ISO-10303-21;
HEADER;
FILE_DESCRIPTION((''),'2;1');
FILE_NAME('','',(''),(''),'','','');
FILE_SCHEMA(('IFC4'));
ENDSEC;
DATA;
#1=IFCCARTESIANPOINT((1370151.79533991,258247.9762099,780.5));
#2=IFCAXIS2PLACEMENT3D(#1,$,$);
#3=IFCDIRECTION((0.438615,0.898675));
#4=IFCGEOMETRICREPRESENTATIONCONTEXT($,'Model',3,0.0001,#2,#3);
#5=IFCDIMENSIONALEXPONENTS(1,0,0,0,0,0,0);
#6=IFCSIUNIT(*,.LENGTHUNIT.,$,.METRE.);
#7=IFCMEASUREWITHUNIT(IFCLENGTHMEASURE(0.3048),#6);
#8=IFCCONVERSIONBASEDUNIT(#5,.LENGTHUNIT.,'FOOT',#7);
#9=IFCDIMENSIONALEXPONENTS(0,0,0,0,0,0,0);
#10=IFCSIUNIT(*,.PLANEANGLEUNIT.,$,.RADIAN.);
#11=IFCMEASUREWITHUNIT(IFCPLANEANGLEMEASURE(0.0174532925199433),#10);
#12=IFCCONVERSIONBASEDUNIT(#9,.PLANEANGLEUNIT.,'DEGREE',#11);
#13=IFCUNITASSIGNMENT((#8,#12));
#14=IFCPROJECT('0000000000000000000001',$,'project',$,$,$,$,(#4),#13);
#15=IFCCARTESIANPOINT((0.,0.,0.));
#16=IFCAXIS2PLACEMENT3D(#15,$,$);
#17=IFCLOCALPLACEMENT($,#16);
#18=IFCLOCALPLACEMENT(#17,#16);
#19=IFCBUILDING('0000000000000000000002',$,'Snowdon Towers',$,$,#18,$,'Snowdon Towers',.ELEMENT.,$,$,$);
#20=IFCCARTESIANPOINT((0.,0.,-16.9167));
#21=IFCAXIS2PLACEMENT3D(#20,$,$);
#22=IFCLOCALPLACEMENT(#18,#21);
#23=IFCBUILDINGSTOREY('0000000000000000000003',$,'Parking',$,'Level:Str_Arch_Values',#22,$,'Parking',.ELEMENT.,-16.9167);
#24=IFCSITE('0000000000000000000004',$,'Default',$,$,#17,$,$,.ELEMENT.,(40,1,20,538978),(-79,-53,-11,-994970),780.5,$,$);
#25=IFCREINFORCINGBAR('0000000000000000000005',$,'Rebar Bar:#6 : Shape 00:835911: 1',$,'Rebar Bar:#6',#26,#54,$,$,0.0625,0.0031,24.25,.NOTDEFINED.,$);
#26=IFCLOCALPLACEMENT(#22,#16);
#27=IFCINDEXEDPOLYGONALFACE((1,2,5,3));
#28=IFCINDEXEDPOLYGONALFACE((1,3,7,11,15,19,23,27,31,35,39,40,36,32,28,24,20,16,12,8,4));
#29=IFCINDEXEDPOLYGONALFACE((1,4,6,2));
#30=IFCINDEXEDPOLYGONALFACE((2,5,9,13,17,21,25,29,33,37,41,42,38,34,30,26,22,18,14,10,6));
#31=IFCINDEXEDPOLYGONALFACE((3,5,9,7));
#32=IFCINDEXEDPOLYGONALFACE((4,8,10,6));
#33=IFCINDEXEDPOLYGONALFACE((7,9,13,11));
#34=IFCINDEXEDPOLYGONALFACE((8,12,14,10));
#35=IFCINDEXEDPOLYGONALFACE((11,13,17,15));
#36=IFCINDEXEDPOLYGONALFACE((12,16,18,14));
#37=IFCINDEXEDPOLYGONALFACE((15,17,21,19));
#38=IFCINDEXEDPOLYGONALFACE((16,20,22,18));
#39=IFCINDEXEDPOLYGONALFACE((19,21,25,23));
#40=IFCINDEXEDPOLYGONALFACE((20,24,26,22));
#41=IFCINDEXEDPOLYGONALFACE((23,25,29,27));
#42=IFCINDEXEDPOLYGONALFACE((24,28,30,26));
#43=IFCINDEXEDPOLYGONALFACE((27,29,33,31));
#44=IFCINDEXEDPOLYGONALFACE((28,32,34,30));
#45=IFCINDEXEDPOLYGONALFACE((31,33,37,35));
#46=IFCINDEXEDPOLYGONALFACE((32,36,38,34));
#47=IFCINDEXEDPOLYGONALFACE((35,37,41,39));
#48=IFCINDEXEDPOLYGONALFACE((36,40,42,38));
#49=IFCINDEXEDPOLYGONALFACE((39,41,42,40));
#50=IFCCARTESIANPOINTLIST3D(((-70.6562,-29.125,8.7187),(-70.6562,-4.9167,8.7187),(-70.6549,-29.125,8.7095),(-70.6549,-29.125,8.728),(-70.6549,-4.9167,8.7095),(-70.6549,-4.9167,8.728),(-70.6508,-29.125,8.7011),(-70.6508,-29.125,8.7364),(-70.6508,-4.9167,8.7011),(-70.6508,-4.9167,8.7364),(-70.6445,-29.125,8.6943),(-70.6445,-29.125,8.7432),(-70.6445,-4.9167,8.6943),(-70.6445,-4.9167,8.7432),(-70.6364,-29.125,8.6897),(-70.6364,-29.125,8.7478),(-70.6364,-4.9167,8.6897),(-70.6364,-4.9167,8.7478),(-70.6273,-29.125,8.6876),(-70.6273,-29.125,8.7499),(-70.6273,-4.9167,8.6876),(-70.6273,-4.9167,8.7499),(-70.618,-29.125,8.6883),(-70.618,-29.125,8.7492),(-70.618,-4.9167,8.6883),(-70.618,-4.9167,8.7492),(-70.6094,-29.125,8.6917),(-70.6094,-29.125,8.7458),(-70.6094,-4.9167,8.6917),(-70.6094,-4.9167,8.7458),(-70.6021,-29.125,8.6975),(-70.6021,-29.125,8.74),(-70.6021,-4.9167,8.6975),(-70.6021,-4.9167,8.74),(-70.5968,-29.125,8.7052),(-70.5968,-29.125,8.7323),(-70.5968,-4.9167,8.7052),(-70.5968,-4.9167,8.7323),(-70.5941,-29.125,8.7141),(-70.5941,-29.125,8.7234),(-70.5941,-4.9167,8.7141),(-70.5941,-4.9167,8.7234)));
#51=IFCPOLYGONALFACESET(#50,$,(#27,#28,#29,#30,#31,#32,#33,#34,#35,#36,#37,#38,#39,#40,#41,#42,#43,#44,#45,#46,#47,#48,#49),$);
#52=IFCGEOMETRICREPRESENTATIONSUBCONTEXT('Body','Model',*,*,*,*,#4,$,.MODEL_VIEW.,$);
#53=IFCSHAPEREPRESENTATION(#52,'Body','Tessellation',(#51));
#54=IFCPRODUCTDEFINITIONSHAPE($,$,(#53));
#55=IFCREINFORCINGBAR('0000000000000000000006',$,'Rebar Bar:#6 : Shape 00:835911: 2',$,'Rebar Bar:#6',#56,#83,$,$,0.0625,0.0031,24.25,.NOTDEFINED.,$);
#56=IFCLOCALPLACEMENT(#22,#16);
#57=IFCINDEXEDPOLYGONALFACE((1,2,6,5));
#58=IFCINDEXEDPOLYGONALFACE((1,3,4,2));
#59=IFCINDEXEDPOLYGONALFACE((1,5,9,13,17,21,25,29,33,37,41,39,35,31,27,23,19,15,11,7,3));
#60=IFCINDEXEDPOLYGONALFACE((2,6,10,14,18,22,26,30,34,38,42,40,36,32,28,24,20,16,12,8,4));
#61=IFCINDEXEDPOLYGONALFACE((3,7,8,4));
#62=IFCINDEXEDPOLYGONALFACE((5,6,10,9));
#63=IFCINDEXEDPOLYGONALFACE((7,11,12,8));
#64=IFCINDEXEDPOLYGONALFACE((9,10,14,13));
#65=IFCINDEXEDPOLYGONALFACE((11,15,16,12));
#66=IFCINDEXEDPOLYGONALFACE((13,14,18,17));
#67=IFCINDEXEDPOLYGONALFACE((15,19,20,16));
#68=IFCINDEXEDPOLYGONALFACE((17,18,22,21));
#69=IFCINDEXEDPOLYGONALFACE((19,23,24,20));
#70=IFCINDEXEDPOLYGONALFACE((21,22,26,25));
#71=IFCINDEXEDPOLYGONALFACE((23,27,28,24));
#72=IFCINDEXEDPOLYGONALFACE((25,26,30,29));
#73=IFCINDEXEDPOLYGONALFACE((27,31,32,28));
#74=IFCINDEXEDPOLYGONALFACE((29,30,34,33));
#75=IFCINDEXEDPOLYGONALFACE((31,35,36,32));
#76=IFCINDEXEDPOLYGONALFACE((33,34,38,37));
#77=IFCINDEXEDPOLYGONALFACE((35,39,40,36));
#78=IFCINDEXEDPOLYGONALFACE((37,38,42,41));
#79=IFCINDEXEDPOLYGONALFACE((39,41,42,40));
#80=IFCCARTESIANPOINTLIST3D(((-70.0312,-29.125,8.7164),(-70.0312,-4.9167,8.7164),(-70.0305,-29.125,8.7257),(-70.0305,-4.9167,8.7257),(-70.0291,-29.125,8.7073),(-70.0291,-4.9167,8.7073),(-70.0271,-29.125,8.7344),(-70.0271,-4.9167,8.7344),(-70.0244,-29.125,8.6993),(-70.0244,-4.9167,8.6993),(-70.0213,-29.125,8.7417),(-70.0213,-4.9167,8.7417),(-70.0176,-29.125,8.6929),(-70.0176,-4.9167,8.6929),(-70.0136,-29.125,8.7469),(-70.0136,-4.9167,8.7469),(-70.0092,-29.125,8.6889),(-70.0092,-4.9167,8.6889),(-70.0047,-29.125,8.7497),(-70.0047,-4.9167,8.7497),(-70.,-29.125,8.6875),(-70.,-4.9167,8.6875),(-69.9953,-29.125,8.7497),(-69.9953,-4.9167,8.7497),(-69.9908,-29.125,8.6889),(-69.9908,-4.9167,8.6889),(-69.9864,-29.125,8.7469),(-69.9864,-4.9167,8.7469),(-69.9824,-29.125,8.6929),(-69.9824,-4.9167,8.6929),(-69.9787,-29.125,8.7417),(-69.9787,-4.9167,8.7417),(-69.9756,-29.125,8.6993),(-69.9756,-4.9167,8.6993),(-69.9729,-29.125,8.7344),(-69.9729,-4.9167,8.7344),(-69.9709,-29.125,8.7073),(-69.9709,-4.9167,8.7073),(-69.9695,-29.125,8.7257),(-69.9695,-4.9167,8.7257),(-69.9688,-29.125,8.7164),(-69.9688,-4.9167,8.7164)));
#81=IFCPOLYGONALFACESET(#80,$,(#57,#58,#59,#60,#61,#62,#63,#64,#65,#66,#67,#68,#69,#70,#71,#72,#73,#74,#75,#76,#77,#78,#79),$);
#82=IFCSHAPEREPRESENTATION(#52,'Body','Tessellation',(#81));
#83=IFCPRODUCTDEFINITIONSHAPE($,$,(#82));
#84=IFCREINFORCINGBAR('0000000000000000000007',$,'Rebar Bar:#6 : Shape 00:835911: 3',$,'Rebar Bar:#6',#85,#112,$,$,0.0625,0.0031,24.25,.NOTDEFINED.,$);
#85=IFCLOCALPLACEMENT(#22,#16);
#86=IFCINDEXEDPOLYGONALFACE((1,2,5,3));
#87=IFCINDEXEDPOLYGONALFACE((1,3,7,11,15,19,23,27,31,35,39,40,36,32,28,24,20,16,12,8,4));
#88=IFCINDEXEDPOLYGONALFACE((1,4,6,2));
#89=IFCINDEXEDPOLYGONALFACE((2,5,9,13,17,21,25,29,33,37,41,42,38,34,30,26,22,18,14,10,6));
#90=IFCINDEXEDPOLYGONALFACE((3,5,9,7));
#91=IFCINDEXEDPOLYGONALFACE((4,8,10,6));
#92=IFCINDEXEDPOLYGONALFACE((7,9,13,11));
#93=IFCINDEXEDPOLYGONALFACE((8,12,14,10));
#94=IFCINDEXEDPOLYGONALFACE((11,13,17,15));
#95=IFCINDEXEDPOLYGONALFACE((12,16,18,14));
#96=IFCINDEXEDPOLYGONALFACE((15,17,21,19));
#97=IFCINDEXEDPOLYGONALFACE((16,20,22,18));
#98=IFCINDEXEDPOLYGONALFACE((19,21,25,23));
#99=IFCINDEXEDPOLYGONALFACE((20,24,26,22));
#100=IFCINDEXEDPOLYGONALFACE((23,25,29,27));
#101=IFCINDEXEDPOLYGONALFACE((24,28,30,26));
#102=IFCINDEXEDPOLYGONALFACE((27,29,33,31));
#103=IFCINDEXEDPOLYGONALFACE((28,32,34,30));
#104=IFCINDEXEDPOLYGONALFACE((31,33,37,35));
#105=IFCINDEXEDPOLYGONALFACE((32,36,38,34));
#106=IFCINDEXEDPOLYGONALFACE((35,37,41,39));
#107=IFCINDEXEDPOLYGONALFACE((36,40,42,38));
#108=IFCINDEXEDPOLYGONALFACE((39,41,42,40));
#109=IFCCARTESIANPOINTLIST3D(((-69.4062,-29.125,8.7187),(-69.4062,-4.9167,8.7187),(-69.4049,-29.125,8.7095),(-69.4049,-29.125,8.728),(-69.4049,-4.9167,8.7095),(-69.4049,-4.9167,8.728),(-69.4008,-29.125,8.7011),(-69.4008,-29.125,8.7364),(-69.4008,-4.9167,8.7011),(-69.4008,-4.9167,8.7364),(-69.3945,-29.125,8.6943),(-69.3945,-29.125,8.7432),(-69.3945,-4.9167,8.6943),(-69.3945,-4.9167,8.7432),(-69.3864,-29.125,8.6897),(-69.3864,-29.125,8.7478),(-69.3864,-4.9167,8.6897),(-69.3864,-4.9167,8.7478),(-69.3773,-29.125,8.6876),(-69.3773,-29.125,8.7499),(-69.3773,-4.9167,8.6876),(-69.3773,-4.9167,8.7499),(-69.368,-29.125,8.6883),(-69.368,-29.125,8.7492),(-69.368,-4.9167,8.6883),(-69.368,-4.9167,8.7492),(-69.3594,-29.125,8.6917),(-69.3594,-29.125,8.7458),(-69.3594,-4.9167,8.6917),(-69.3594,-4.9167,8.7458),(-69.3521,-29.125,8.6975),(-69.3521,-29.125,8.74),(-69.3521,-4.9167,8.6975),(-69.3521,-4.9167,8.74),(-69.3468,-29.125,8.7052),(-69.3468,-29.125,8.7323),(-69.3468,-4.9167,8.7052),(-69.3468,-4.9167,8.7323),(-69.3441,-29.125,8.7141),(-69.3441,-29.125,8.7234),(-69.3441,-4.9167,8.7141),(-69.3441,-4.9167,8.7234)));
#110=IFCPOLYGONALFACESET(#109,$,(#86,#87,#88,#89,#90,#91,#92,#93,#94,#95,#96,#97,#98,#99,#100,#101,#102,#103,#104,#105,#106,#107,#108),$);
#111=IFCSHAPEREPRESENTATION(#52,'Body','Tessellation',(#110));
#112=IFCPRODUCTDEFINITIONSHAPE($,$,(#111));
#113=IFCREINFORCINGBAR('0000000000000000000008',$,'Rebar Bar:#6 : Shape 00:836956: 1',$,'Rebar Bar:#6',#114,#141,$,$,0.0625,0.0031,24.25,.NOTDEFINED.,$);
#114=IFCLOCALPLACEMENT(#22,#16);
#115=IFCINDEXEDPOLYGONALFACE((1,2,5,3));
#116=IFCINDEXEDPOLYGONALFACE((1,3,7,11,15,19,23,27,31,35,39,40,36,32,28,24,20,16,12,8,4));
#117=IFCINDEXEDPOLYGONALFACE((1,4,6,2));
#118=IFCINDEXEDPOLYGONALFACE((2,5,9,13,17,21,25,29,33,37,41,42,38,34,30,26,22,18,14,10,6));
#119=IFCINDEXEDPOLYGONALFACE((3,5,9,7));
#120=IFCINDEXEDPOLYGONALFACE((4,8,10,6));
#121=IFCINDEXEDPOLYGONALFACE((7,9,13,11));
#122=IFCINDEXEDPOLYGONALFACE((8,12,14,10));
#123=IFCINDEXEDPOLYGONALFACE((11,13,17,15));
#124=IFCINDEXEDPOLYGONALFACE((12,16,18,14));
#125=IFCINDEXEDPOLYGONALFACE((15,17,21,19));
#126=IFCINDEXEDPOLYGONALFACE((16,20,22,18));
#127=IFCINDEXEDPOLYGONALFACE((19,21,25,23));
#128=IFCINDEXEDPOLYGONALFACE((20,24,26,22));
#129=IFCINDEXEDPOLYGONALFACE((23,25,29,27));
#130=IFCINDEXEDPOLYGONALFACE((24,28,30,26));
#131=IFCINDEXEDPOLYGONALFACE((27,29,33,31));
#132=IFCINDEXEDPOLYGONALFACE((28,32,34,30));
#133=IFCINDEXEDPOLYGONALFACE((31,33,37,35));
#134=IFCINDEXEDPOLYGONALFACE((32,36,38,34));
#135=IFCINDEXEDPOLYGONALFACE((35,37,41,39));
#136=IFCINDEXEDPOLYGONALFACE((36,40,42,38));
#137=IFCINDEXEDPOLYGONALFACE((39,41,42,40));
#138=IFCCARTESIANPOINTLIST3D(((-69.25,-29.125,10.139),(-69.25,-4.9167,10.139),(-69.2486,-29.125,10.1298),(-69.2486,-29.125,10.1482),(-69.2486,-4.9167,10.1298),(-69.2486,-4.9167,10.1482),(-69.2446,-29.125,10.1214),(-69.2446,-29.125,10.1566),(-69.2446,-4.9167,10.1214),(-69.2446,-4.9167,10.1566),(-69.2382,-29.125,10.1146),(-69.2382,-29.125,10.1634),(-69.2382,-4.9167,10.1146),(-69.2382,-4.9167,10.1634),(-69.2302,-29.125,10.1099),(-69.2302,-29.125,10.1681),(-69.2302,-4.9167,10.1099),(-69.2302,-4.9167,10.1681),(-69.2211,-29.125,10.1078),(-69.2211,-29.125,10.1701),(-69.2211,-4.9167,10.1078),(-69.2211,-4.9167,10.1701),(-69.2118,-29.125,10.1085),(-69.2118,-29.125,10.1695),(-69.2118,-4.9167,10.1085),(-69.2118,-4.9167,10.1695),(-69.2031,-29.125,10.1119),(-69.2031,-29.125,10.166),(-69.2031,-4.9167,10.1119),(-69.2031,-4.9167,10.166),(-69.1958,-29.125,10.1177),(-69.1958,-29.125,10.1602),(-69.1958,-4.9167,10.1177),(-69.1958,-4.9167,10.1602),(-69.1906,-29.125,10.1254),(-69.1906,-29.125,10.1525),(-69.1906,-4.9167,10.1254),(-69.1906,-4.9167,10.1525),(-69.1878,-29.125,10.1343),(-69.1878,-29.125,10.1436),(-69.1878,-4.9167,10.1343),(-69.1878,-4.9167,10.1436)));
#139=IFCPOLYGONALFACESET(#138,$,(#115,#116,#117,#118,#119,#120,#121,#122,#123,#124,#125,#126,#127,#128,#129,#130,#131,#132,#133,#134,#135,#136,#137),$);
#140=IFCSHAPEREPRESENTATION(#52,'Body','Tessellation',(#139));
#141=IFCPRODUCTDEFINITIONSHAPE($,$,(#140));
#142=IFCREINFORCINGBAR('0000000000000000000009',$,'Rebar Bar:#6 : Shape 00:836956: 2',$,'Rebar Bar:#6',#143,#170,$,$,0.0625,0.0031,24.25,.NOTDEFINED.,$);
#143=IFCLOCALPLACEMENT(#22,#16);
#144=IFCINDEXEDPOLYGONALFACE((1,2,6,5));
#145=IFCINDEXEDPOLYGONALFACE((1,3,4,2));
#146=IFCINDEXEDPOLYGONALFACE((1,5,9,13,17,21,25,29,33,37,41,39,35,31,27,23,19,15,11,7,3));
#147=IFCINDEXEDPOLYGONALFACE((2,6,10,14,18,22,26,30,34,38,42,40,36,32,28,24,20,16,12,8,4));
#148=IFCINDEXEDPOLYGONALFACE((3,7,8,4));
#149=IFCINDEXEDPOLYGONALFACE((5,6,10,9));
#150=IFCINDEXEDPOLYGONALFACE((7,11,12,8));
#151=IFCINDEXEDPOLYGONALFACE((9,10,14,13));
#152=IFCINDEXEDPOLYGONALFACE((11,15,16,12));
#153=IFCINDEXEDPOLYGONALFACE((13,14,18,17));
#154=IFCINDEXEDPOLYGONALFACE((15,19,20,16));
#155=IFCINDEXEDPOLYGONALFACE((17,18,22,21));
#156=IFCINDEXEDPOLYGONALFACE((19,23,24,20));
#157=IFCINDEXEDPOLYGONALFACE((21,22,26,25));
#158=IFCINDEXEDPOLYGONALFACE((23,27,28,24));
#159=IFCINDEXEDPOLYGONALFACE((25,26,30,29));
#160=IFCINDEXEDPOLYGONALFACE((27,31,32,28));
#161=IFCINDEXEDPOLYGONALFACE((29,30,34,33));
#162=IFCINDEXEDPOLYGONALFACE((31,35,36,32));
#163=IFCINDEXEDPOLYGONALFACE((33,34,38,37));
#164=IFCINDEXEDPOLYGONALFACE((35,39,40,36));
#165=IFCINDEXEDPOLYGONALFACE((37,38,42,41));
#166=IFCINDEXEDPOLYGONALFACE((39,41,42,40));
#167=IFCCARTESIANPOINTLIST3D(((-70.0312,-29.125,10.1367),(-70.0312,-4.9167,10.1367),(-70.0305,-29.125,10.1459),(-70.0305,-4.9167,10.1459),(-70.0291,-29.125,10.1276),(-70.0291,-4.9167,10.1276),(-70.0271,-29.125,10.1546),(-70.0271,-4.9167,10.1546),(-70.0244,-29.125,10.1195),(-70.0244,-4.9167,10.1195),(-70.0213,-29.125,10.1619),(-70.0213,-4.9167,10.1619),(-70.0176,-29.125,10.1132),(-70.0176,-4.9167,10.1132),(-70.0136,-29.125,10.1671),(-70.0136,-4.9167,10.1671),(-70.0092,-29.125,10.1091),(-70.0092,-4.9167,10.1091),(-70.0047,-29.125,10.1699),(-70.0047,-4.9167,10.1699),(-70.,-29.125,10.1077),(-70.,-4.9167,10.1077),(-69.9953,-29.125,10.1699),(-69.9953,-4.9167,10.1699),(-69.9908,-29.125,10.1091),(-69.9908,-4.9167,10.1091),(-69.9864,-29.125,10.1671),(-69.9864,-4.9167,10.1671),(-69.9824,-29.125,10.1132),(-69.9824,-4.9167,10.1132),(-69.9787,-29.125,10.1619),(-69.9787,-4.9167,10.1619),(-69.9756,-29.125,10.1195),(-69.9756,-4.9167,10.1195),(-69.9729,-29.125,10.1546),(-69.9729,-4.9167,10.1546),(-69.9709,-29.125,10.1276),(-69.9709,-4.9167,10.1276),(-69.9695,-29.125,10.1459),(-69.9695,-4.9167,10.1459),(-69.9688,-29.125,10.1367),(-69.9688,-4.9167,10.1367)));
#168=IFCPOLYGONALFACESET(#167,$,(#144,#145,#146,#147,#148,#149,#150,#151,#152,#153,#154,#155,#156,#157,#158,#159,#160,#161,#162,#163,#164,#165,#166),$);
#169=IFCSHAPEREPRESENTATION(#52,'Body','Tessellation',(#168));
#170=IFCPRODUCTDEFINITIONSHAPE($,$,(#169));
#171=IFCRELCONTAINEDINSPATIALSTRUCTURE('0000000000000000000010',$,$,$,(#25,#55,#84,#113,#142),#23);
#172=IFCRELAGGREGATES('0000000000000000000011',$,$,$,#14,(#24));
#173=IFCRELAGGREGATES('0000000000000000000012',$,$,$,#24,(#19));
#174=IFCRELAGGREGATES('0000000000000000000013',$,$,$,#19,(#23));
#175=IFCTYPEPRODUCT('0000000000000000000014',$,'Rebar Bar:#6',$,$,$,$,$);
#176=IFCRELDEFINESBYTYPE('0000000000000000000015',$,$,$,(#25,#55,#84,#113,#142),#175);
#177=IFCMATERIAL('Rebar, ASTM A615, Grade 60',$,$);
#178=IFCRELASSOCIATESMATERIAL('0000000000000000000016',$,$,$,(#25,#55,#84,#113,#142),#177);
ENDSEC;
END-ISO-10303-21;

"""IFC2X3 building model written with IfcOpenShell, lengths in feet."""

from ifc_helpers import new_model, entity, si_unit, converted_unit, direction, frame, origin, place, context, subcontext, project, spatial, material, type_object, element, save


model = new_model("IFC2X3")

# Units and contexts
model_context = context("Model", 3, precision=0.0001, world=frame((1370151.79533991, 258247.9762099, 780.5)), true_north=direction((0.438615, 0.898675)))
body_context = subcontext(model_context, "Body", "Model", "MODEL_VIEW")
ifc_project = project(units=[converted_unit("LENGTHUNIT", "FOOT", entity("IfcLengthMeasure", 0.3048), si_unit("LENGTHUNIT", "METRE"), dimensions=[1, 0, 0, 0, 0, 0, 0]), converted_unit("PLANEANGLEUNIT", "DEGREE", entity("IfcPlaneAngleMeasure", 0.0174532925199433), si_unit("PLANEANGLEUNIT", "RADIAN"), dimensions=[0, 0, 0, 0, 0, 0, 0])], contexts=[model_context])

# Site, building, storey
site_placement = place(None, origin())
site = spatial("IfcSite", under=ifc_project, at=site_placement, Name="Default", CompositionType="ELEMENT", RefLatitude=(40, 1, 20, 538978), RefLongitude=(-79, -53, -11, -994970), RefElevation=780.5)
building_placement = place(site_placement, origin())
building = spatial("IfcBuilding", under=site, at=building_placement, Name="Snowdon Towers", LongName="Snowdon Towers", CompositionType="ELEMENT")
storey_placement = place(building_placement, frame((0.0, 0.0, -16.9167)))
storey = spatial("IfcBuildingStorey", under=building, at=storey_placement, Name="Parking", ObjectType="Level:Str_Arch_Values", LongName="Parking", CompositionType="ELEMENT", Elevation=-16.9167)

# Reinforcing bars
ifc_material = material(Name="Rebar, ASTM A615, Grade 60")
type_product = type_object("IfcTypeProduct", Name="Rebar Bar:#6")
reinforcing_bar_1_placement = place(storey_placement, origin())
element("IfcReinforcingBar", 1, at=reinforcing_bar_1_placement, inside=storey, type_object=type_product, material=ifc_material, Name="Rebar Bar:#6 : Shape 00:835911: 1", ObjectType="Rebar Bar:#6", BarLength=24.25, BarRole="NOTDEFINED", CrossSectionArea=0.0031, NominalDiameter=0.0625, context=body_context, shape_type="AdvancedSweptSolid", body=[
    entity("IfcSweptDiskSolid", entity("IfcCompositeCurve", [entity("IfcCompositeCurveSegment", "CONTINUOUS", True, entity("IfcPolyline", [entity("IfcCartesianPoint", [-70.625, -4.9167, 8.7187]), entity("IfcCartesianPoint", [-70.625, -29.125, 8.7187])]))], False), 0.0312, None, 0.0, 1.0),
])
reinforcing_bar_2_placement = place(storey_placement, origin())
element("IfcReinforcingBar", 2, at=reinforcing_bar_2_placement, inside=storey, type_object=type_product, material=ifc_material, Name="Rebar Bar:#6 : Shape 00:835911: 2", ObjectType="Rebar Bar:#6", BarLength=24.25, BarRole="NOTDEFINED", CrossSectionArea=0.0031, NominalDiameter=0.0625, context=body_context, shape_type="AdvancedSweptSolid", body=[
    entity("IfcSweptDiskSolid", entity("IfcCompositeCurve", [entity("IfcCompositeCurveSegment", "CONTINUOUS", True, entity("IfcPolyline", [entity("IfcCartesianPoint", [-70.0, -4.9167, 8.7187]), entity("IfcCartesianPoint", [-70.0, -29.125, 8.7187])]))], False), 0.0312, None, 0.0, 1.0),
])
reinforcing_bar_3_placement = place(storey_placement, origin())
element("IfcReinforcingBar", 3, at=reinforcing_bar_3_placement, inside=storey, type_object=type_product, material=ifc_material, Name="Rebar Bar:#6 : Shape 00:835911: 3", ObjectType="Rebar Bar:#6", BarLength=24.25, BarRole="NOTDEFINED", CrossSectionArea=0.0031, NominalDiameter=0.0625, context=body_context, shape_type="AdvancedSweptSolid", body=[
    entity("IfcSweptDiskSolid", entity("IfcCompositeCurve", [entity("IfcCompositeCurveSegment", "CONTINUOUS", True, entity("IfcPolyline", [entity("IfcCartesianPoint", [-69.375, -4.9167, 8.7187]), entity("IfcCartesianPoint", [-69.375, -29.125, 8.7187])]))], False), 0.0312, None, 0.0, 1.0),
])
reinforcing_bar_4_placement = place(storey_placement, origin())
element("IfcReinforcingBar", 4, at=reinforcing_bar_4_placement, inside=storey, type_object=type_product, material=ifc_material, Name="Rebar Bar:#6 : Shape 00:836956: 1", ObjectType="Rebar Bar:#6", BarLength=24.25, BarRole="NOTDEFINED", CrossSectionArea=0.0031, NominalDiameter=0.0625, context=body_context, shape_type="AdvancedSweptSolid", body=[
    entity("IfcSweptDiskSolid", entity("IfcCompositeCurve", [entity("IfcCompositeCurveSegment", "CONTINUOUS", True, entity("IfcPolyline", [entity("IfcCartesianPoint", [-69.2187, -4.9167, 10.139]), entity("IfcCartesianPoint", [-69.2187, -29.125, 10.139])]))], False), 0.0312, None, 0.0, 1.0),
])
reinforcing_bar_5_placement = place(storey_placement, origin())
element("IfcReinforcingBar", 5, at=reinforcing_bar_5_placement, inside=storey, type_object=type_product, material=ifc_material, Name="Rebar Bar:#6 : Shape 00:836956: 2", ObjectType="Rebar Bar:#6", BarLength=24.25, BarRole="NOTDEFINED", CrossSectionArea=0.0031, NominalDiameter=0.0625, context=body_context, shape_type="AdvancedSweptSolid", body=[
    entity("IfcSweptDiskSolid", entity("IfcCompositeCurve", [entity("IfcCompositeCurveSegment", "CONTINUOUS", True, entity("IfcPolyline", [entity("IfcCartesianPoint", [-70.0, -4.9167, 10.139]), entity("IfcCartesianPoint", [-70.0, -29.125, 10.139])]))], False), 0.0312, None, 0.0, 1.0),
])

save(model, "model.ifc")
